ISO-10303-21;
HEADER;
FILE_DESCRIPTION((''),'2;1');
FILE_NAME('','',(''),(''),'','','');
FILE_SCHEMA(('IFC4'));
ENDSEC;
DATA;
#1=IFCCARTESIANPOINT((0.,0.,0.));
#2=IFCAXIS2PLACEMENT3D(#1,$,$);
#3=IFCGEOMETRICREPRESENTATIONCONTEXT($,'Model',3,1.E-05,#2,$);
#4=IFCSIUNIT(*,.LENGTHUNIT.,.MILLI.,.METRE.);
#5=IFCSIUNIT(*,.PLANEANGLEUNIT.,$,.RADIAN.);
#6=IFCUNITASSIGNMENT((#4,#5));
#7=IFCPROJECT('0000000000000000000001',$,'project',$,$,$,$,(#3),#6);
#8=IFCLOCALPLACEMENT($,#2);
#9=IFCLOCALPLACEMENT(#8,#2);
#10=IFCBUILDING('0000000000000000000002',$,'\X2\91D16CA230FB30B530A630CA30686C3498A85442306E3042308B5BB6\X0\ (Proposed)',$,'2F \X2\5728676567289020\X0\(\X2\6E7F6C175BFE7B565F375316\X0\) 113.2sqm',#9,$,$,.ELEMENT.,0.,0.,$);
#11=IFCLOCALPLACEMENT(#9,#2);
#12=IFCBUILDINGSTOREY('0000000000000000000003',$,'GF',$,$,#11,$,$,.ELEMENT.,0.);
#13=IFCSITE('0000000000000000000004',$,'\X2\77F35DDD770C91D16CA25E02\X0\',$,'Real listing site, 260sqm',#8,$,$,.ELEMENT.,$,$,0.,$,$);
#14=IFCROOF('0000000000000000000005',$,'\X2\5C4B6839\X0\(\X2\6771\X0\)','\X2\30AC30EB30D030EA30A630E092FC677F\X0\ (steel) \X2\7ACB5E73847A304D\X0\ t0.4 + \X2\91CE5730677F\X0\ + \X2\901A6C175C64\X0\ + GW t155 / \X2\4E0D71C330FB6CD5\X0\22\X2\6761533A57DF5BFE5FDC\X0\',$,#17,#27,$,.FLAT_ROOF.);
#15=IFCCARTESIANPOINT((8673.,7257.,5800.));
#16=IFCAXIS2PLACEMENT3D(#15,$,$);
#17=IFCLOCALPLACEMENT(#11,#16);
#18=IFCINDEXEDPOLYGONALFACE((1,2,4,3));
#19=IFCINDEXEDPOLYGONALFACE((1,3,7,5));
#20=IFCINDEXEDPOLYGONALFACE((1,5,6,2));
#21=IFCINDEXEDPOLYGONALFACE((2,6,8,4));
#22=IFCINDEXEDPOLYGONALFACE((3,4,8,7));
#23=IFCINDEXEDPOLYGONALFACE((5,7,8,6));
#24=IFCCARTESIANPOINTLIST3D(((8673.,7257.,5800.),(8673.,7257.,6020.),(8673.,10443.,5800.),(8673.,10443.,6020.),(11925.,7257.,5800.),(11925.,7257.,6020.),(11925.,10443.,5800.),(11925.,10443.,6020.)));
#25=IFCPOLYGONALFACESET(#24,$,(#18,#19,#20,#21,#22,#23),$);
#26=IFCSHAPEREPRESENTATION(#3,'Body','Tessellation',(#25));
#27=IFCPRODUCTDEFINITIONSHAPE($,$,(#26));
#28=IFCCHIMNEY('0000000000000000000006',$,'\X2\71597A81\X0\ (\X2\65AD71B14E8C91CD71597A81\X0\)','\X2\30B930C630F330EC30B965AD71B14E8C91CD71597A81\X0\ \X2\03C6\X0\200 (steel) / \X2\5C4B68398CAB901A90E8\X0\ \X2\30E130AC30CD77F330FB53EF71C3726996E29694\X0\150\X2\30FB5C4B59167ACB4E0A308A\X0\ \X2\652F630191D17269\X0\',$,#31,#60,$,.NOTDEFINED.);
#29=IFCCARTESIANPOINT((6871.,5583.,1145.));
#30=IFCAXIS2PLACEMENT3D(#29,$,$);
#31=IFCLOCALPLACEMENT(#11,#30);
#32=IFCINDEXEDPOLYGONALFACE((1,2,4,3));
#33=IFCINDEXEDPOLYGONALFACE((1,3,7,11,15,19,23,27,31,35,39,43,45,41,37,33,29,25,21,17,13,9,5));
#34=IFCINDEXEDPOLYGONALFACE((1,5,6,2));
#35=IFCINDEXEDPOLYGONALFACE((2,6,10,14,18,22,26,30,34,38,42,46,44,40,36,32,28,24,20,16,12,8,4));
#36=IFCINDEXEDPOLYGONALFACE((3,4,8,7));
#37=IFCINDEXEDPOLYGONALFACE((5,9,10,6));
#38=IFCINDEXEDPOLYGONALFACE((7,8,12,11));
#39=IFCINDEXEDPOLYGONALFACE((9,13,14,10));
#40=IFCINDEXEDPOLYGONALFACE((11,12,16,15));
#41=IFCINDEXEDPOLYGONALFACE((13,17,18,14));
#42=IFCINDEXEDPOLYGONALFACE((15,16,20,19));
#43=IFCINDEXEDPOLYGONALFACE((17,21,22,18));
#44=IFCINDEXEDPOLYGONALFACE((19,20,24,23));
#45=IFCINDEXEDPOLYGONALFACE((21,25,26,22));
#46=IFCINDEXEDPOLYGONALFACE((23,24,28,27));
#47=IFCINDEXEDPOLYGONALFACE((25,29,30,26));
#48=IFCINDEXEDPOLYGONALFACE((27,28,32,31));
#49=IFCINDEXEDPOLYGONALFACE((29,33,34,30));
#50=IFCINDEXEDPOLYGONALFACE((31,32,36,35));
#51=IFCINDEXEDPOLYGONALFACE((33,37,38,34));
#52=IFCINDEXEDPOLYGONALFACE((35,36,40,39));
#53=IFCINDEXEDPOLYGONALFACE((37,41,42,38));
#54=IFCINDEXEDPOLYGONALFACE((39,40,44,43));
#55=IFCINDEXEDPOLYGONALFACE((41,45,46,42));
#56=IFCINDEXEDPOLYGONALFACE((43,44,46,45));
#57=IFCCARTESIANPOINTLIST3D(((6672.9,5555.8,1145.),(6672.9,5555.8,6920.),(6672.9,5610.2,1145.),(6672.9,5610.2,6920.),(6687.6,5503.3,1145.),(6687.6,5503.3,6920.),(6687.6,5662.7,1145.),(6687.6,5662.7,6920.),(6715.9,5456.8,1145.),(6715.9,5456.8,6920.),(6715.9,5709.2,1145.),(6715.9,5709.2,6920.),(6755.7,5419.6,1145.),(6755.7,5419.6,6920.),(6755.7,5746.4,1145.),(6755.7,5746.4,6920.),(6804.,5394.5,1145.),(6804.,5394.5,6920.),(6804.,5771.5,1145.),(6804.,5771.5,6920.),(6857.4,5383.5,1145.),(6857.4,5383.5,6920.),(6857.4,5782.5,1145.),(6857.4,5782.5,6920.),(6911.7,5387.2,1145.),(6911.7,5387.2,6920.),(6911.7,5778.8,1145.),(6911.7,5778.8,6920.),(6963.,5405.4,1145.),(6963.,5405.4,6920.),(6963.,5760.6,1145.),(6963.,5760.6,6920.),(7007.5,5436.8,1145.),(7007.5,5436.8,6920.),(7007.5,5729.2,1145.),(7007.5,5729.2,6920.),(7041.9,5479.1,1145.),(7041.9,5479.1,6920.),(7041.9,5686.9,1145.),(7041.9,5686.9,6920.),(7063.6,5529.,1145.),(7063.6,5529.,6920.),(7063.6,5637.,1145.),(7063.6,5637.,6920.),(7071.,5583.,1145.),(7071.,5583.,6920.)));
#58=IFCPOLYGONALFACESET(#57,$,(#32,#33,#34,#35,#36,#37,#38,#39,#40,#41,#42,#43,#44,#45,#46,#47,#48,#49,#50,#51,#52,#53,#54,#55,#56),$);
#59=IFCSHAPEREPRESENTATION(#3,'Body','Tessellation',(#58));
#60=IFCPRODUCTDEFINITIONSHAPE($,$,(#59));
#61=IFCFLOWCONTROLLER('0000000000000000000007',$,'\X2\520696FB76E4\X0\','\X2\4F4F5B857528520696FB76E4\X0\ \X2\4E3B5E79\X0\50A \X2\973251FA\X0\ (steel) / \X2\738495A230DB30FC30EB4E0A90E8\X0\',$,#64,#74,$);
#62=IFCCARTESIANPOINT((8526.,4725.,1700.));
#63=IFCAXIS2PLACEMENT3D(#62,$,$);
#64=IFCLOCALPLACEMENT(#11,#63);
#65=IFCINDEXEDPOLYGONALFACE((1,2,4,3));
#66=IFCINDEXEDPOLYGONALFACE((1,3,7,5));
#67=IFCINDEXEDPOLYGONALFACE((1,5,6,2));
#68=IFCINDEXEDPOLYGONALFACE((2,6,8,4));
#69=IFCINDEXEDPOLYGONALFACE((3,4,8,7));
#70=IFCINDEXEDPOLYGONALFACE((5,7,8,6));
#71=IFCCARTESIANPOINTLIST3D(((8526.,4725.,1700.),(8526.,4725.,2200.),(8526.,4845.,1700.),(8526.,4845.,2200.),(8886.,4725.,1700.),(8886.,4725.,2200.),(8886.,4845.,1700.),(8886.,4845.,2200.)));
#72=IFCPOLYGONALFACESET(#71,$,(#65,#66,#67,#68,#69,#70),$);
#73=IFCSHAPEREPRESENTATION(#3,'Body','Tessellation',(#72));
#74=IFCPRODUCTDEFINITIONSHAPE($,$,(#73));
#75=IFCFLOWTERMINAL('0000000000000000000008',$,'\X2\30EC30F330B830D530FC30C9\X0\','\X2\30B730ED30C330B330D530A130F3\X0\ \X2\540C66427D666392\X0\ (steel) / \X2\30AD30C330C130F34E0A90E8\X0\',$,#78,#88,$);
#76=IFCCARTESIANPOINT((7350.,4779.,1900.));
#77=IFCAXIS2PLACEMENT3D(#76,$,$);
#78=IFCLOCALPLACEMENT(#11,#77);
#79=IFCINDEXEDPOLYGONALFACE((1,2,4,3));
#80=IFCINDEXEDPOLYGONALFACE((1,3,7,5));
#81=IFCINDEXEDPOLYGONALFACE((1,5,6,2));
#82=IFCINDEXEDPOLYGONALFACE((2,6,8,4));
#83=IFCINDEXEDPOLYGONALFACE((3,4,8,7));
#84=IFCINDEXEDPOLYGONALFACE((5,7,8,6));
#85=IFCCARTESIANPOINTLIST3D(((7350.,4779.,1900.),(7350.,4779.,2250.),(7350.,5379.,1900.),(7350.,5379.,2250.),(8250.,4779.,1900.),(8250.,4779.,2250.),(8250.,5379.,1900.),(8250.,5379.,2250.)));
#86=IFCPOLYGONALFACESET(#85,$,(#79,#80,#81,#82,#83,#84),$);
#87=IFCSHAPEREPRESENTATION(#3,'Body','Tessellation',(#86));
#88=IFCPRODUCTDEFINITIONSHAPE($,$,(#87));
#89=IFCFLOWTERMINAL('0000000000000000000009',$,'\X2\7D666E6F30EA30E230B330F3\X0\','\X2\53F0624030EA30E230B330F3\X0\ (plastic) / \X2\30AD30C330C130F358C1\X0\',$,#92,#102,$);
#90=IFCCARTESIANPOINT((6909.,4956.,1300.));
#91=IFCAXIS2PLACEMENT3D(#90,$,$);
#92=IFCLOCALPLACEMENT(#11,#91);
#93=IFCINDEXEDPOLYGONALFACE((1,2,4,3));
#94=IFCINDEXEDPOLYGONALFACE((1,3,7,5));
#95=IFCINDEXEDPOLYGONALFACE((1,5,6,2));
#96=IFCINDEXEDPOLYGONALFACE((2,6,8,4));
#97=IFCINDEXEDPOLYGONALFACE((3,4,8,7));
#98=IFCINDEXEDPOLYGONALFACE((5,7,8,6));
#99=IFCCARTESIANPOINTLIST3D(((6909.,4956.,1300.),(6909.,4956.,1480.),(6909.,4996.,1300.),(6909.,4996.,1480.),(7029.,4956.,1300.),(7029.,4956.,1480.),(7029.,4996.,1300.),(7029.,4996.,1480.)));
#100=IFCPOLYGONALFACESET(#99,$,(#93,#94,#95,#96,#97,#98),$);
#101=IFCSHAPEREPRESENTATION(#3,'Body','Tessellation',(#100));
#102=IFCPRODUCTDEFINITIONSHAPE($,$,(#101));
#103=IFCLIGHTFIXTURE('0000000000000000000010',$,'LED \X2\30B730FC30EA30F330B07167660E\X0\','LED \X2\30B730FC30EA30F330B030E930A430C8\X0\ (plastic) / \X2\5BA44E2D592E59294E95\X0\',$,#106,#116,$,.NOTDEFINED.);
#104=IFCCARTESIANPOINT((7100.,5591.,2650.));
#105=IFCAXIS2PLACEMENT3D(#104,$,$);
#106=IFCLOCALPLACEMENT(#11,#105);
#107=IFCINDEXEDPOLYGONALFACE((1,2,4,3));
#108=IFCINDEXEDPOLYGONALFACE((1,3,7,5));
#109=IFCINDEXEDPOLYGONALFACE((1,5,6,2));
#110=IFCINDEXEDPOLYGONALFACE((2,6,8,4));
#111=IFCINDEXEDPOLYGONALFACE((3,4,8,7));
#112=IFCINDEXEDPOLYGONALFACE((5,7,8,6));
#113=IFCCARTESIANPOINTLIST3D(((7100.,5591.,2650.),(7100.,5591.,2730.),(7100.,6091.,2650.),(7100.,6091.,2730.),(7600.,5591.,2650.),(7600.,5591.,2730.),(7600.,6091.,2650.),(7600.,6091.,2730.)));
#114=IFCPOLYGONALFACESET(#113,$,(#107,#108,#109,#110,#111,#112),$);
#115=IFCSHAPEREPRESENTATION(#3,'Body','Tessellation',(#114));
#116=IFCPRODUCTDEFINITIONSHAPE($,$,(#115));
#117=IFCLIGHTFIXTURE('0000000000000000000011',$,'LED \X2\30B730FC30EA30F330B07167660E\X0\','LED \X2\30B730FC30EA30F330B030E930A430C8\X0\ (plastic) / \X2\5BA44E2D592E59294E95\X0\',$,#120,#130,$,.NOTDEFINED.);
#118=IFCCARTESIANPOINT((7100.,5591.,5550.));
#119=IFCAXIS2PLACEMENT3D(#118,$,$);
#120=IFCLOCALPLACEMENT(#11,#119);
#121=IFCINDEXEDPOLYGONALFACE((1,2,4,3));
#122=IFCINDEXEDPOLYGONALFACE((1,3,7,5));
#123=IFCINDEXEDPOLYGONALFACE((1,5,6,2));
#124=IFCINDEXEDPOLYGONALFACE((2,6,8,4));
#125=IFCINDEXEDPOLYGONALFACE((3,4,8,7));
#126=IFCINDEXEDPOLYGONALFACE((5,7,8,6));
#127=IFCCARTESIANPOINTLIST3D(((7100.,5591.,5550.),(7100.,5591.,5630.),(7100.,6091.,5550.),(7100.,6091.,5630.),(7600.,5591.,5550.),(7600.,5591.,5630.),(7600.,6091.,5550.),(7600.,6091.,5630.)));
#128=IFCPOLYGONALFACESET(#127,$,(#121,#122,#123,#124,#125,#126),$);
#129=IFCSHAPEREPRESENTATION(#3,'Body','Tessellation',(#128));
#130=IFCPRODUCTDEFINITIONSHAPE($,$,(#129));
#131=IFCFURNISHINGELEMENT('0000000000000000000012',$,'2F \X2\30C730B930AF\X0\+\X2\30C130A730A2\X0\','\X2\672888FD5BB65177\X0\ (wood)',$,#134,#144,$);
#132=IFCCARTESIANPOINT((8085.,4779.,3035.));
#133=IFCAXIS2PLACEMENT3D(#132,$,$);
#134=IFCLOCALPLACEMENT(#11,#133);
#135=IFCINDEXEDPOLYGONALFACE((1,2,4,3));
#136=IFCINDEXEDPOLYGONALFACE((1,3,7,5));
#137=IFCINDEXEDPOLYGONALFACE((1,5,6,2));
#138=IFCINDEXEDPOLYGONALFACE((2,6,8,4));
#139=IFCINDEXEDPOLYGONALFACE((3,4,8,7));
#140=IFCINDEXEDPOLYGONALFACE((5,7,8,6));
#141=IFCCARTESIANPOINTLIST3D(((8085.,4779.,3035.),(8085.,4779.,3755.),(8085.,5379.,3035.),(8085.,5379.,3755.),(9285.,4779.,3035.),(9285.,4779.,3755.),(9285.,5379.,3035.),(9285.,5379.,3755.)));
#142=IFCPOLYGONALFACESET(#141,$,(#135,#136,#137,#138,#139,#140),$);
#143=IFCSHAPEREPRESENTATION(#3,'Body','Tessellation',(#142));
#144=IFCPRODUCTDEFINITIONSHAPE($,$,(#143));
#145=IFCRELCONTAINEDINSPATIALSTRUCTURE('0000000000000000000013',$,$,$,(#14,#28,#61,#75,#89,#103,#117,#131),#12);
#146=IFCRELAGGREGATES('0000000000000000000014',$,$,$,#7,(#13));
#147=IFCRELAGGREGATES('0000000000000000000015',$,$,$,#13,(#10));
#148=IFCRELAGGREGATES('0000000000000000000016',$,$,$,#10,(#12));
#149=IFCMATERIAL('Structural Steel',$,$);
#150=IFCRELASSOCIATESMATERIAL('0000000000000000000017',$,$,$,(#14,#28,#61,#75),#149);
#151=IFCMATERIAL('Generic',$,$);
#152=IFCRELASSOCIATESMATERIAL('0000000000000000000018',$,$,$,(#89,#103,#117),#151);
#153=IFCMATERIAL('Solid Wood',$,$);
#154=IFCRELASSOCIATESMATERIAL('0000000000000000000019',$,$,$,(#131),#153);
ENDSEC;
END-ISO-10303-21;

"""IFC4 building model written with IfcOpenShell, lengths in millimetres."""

from ifc_helpers import new_model, si_unit, frame, frame_2d, origin, origin_2d, place, context, project, spatial, rectangle, circle, extrude, material, element, save


model = new_model("IFC4")

# Units and contexts
model_context = context("Model", 3, precision=1e-05, world=origin())
ifc_project = project(units=[si_unit("LENGTHUNIT", "METRE", prefix="MILLI"), si_unit("PLANEANGLEUNIT", "RADIAN")], contexts=[model_context])

# Site, building, storey
site_placement = place(None, origin())
site = spatial("IfcSite", under=ifc_project, at=site_placement, Name="石川県金沢市", ObjectType="Real listing site, 260sqm", CompositionType="ELEMENT", RefElevation=0.0)
building_placement = place(site_placement, origin())
building = spatial("IfcBuilding", under=site, at=building_placement, Name="金沢・サウナと水風呂のある家 (Proposed)", ObjectType="2F 在来木造(湿気対策強化) 113.2sqm", CompositionType="ELEMENT", ElevationOfRefHeight=0.0, ElevationOfTerrain=0.0)
storey_placement = place(building_placement, origin())
storey = spatial("IfcBuildingStorey", under=building, at=storey_placement, Name="GF", CompositionType="ELEMENT", Elevation=0.0)

# Shared definitions
ifc_material_1 = material(Name="Solid Wood")

# Roof
ifc_material_2 = material(Name="Structural Steel")
for number, where, name in (
    (1, (8673.0, 7257.0, 5800.0), "屋根(東)"),
):
    element("IfcRoof", number, at=place(storey_placement, frame(where)), inside=storey, material=ifc_material_2, Name=name, Description="ガルバリウム鋼板 (steel) 立平葺き t0.4 + 野地板 + 通気層 + GW t155 / 不燃・法22条区域対応", PredefinedType="FLAT_ROOF", context=model_context, shape_type="SweptSolid", body=[
        extrude(rectangle(XDim=3252.0, YDim=3186.0, at=frame_2d((1626.0, 1593.0))), frame((8673.0, 7257.0, 5800.0)), (0.0, 0.0, 1.0), 220.0),
    ])

# Chimney
chimney_placement = place(storey_placement, frame((6871.0, 5583.0, 1145.0)))
element("IfcChimney", 2, at=chimney_placement, inside=storey, material=ifc_material_2, Name="煙突 (断熱二重煙突)", Description="ステンレス断熱二重煙突 φ200 (steel) / 屋根貫通部 メガネ石・可燃物離隔150・屋外立上り 支持金物", PredefinedType="NOTDEFINED", context=model_context, shape_type="SweptSolid", body=[
    extrude(circle(Radius=200.0, at=origin_2d()), frame((6871.0, 5583.0, 1145.0)), (0.0, 0.0, 1.0), 5775.0),
])

# Flow controller
flow_controller_placement = place(storey_placement, frame((8526.0, 4725.0, 1700.0)))
element("IfcFlowController", 3, at=flow_controller_placement, inside=storey, material=ifc_material_2, Name="分電盤", Description="住宅用分電盤 主幹50A 露出 (steel) / 玄関ホール上部", context=model_context, shape_type="SweptSolid", body=[
    extrude(rectangle(XDim=360.0, YDim=120.0, at=frame_2d((180.0, 60.0))), frame((8526.0, 4725.0, 1700.0)), (0.0, 0.0, 1.0), 500.0),
])

# Flow terminals
flow_terminal_1_placement = place(storey_placement, frame((7350.0, 4779.0, 1900.0)))
element("IfcFlowTerminal", 4, at=flow_terminal_1_placement, inside=storey, material=ifc_material_2, Name="レンジフード", Description="シロッコファン 同時給排 (steel) / キッチン上部", context=model_context, shape_type="SweptSolid", body=[
    extrude(rectangle(XDim=900.0, YDim=600.0, at=frame_2d((450.0, 300.0))), frame((7350.0, 4779.0, 1900.0)), (0.0, 0.0, 1.0), 350.0),
])
ifc_material_3 = material(Name="Generic")
flow_terminal_2_placement = place(storey_placement, frame((6909.0, 4956.0, 1300.0)))
element("IfcFlowTerminal", 5, at=flow_terminal_2_placement, inside=storey, material=ifc_material_3, Name="給湯リモコン", Description="台所リモコン (plastic) / キッチン壁", context=model_context, shape_type="SweptSolid", body=[
    extrude(rectangle(XDim=120.0, YDim=40.0, at=frame_2d((60.0, 20.0))), frame((6909.0, 4956.0, 1300.0)), (0.0, 0.0, 1.0), 180.0),
])

# Light fixtures
light_fixture_1_placement = place(storey_placement, frame((7100.0, 5591.0, 2650.0)))
element("IfcLightFixture", 6, at=light_fixture_1_placement, inside=storey, material=ifc_material_3, Name="LED シーリング照明", Description="LED シーリングライト (plastic) / 室中央天井", PredefinedType="NOTDEFINED", context=model_context, shape_type="SweptSolid", body=[
    extrude(rectangle(XDim=500.0, YDim=500.0, at=frame_2d((250.0, 250.0))), frame((7100.0, 5591.0, 2650.0)), (0.0, 0.0, 1.0), 80.0),
])
light_fixture_2_placement = place(storey_placement, frame((7100.0, 5591.0, 5550.0)))
element("IfcLightFixture", 7, at=light_fixture_2_placement, inside=storey, material=ifc_material_3, Name="LED シーリング照明", Description="LED シーリングライト (plastic) / 室中央天井", PredefinedType="NOTDEFINED", context=model_context, shape_type="SweptSolid", body=[
    extrude(rectangle(XDim=500.0, YDim=500.0, at=frame_2d((250.0, 250.0))), frame((7100.0, 5591.0, 5550.0)), (0.0, 0.0, 1.0), 80.0),
])

# Furnishing element
furnishing_placement = place(storey_placement, frame((8085.0, 4779.0, 3035.0)))
element("IfcFurnishingElement", 8, at=furnishing_placement, inside=storey, material=ifc_material_1, Name="2F デスク+チェア", Description="木製家具 (wood)", context=model_context, shape_type="SweptSolid", body=[
    extrude(rectangle(XDim=1200.0, YDim=600.0, at=frame_2d((600.0, 300.0))), frame((8085.0, 4779.0, 3035.0)), (0.0, 0.0, 1.0), 720.0),
])

save(model, "model.ifc")
